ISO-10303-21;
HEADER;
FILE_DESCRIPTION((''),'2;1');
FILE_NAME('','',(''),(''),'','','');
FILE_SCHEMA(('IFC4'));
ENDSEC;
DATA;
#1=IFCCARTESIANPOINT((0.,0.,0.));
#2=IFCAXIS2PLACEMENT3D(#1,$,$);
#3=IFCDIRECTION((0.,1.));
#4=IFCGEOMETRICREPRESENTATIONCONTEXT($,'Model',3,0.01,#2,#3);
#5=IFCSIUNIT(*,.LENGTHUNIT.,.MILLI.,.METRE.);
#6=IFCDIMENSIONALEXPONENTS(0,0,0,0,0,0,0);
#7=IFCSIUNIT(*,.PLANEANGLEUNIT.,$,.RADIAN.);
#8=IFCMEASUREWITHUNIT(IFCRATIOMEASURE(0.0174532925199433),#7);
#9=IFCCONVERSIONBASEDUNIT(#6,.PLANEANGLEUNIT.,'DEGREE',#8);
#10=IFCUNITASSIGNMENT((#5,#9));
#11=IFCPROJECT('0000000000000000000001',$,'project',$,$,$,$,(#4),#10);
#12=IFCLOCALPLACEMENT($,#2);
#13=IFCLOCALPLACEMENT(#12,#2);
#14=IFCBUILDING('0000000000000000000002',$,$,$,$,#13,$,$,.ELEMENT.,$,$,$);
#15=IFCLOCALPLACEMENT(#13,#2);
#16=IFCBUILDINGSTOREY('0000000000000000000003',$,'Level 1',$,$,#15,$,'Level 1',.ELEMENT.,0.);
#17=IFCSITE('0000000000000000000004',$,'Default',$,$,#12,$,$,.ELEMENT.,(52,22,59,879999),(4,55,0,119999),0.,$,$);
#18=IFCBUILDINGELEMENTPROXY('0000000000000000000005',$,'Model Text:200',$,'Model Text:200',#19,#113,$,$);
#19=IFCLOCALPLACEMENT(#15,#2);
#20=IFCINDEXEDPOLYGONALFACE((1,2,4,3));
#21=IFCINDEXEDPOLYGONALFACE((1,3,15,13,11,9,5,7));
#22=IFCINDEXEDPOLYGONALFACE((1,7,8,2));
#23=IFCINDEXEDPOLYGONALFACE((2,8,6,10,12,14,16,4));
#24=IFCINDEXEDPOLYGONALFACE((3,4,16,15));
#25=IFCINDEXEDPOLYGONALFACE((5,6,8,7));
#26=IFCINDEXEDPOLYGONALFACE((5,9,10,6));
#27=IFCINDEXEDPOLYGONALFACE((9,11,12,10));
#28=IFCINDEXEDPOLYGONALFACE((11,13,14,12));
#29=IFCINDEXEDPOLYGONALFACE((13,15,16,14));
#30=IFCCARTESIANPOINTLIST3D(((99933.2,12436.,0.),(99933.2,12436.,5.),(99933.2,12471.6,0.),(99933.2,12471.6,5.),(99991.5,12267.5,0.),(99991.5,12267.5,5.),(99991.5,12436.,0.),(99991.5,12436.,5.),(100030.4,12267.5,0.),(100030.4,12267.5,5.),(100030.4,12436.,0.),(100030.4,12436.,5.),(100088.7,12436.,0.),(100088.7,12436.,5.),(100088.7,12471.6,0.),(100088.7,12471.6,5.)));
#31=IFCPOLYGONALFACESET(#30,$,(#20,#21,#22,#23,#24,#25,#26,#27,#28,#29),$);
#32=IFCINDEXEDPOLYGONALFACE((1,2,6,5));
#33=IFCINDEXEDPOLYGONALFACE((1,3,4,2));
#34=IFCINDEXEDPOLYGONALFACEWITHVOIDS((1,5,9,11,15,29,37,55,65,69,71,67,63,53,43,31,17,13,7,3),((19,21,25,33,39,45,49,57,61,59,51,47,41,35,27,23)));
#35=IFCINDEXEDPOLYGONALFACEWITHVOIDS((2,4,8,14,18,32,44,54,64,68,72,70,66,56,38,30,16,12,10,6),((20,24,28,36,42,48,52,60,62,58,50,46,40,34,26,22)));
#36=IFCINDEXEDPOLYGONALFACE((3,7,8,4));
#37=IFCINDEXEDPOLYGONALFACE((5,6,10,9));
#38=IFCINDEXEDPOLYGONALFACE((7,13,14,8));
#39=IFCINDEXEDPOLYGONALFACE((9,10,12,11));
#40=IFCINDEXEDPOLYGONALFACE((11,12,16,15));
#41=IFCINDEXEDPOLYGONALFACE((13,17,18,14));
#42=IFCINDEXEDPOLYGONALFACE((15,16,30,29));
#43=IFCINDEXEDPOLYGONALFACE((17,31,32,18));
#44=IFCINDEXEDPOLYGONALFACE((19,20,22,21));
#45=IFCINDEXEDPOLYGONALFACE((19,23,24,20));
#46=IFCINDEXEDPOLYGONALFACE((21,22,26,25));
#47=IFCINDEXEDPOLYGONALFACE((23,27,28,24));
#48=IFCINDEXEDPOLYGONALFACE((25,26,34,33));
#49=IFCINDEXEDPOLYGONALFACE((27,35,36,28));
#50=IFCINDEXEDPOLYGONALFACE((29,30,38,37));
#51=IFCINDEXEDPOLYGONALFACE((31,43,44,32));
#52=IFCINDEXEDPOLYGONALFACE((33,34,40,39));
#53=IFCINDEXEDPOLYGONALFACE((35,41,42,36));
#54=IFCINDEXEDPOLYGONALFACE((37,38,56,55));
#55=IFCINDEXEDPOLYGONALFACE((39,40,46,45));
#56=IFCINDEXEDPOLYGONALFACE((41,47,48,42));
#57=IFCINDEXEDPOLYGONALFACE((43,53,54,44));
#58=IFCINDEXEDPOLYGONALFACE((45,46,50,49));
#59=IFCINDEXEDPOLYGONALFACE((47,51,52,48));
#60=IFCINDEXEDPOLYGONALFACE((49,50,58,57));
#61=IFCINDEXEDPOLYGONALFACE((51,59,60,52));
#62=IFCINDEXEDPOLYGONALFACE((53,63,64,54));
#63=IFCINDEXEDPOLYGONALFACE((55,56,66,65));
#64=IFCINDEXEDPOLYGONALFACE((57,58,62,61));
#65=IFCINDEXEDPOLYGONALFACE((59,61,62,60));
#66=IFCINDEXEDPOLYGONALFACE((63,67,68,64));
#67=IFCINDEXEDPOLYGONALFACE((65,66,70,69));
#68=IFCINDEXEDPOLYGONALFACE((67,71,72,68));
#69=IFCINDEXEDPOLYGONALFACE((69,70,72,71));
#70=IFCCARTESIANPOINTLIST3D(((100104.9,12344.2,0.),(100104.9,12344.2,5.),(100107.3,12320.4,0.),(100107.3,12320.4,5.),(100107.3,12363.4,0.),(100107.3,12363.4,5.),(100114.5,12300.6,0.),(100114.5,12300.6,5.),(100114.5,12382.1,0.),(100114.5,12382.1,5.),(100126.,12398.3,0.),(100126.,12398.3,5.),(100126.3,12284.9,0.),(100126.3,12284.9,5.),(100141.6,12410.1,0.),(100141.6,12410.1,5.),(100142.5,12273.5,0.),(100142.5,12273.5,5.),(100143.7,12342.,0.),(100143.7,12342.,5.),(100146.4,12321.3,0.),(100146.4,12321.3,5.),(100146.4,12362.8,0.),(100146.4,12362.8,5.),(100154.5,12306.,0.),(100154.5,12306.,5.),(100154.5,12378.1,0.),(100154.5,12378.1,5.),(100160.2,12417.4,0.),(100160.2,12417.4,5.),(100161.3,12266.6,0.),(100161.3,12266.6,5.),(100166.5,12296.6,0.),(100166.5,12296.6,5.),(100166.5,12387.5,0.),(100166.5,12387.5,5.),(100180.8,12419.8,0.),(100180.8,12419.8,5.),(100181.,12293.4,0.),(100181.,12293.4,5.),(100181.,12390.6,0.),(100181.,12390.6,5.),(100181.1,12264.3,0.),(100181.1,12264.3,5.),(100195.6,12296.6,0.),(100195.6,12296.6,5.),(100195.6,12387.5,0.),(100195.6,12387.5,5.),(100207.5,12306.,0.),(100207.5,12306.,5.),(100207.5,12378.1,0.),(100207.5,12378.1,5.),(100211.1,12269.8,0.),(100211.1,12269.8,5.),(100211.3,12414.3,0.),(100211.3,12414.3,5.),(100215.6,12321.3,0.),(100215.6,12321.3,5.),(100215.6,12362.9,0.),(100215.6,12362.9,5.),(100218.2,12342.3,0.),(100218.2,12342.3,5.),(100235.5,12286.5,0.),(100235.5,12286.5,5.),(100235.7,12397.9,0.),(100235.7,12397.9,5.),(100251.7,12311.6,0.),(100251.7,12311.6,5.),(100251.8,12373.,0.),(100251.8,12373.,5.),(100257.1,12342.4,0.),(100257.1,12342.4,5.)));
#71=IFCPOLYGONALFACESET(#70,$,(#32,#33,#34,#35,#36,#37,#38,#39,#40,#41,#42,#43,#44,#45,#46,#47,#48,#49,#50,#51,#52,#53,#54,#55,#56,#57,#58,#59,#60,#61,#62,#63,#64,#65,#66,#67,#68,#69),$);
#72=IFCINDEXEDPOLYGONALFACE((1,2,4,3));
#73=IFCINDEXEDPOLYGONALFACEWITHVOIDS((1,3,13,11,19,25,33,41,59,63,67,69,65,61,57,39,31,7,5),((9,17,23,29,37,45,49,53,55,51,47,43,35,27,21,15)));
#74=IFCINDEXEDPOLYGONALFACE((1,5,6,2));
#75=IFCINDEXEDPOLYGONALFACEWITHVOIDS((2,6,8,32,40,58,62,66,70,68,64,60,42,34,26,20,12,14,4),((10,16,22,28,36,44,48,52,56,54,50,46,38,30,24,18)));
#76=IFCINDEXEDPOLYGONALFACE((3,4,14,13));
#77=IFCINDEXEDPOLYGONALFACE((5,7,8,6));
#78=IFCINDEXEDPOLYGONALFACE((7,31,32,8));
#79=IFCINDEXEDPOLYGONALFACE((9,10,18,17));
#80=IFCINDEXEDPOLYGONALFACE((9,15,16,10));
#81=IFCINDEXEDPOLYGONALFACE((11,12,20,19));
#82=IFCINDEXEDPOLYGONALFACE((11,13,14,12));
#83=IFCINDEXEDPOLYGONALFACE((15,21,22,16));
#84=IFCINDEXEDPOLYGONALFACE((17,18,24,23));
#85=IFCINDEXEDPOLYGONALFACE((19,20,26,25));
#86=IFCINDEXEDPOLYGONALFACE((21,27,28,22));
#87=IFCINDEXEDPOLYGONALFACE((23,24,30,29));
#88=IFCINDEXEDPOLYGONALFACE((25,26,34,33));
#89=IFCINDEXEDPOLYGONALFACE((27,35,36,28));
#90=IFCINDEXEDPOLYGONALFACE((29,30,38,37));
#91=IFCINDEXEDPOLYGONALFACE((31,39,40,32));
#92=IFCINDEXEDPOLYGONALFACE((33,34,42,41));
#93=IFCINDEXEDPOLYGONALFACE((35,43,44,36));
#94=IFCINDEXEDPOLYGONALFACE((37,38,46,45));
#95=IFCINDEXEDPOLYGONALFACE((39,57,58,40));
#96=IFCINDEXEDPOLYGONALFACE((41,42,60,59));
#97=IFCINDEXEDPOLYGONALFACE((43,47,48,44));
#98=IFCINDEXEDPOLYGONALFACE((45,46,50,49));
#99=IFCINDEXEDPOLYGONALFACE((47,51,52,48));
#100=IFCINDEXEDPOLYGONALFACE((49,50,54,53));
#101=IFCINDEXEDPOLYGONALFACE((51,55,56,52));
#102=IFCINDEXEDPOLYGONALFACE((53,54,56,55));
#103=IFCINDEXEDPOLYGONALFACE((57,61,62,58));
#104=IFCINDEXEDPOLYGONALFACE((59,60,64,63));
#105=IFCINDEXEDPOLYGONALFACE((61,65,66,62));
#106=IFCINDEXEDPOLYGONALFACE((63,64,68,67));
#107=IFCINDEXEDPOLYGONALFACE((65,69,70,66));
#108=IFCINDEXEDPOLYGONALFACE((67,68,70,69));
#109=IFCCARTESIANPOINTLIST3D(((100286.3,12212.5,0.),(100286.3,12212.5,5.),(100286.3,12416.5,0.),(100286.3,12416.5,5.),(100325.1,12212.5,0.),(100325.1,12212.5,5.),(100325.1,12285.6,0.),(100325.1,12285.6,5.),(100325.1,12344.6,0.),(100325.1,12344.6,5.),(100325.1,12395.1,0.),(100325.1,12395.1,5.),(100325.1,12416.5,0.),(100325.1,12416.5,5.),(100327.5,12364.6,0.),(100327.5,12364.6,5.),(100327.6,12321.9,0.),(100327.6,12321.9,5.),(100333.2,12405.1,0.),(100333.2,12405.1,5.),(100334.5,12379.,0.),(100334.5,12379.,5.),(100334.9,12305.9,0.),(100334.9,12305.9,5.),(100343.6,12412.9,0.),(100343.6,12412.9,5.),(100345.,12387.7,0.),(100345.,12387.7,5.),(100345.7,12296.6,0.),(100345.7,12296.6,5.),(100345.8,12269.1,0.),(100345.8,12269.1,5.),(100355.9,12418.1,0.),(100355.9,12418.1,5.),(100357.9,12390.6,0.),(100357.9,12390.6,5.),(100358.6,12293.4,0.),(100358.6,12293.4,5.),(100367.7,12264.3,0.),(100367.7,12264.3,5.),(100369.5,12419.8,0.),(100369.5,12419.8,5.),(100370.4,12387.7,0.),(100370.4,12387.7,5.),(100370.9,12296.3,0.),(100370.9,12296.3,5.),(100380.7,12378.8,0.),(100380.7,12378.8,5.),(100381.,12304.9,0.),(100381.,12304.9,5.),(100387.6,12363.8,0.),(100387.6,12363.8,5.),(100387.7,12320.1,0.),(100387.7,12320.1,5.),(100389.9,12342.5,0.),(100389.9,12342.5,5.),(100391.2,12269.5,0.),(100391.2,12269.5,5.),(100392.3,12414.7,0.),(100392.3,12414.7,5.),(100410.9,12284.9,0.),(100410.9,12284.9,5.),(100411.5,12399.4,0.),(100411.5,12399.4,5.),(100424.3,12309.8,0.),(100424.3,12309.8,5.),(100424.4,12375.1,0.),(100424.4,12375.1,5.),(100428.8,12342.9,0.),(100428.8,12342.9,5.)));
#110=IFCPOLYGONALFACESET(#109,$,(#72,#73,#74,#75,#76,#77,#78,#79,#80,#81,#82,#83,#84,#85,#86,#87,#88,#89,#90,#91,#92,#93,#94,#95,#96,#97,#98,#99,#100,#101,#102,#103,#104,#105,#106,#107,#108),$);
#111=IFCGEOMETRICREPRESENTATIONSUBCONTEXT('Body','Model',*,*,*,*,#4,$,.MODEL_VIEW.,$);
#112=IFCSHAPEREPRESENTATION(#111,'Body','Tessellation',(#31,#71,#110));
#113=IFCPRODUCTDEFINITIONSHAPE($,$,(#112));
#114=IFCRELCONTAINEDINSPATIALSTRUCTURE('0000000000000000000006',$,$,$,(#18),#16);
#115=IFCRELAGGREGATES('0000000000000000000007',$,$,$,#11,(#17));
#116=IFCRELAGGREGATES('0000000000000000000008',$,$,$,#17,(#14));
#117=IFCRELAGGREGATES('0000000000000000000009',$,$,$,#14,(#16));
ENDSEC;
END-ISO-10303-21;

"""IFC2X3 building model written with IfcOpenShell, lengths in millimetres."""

from ifc_helpers import new_model, entity, si_unit, converted_unit, direction, frame, origin, place, context, subcontext, project, spatial, polyline, outline, extrude, element, save


model = new_model("IFC2X3")

# Units and contexts
model_context = context("Model", 3, precision=0.01, world=origin(), true_north=direction((0.0, 1.0)))
body_context = subcontext(model_context, "Body", "Model", "MODEL_VIEW")
ifc_project = project(units=[si_unit("LENGTHUNIT", "METRE", prefix="MILLI"), converted_unit("PLANEANGLEUNIT", "DEGREE", entity("IfcRatioMeasure", 0.0174532925199433), si_unit("PLANEANGLEUNIT", "RADIAN"), dimensions=[0, 0, 0, 0, 0, 0, 0])], contexts=[model_context])

# Site, building, storey
site_placement = place(None, origin())
site = spatial("IfcSite", under=ifc_project, at=site_placement, Name="Default", CompositionType="ELEMENT", RefLatitude=(52, 22, 59, 879999), RefLongitude=(4, 55, 0, 119999), RefElevation=0.0)
building_placement = place(site_placement, origin())
building = spatial("IfcBuilding", under=site, at=building_placement, CompositionType="ELEMENT")
storey_placement = place(building_placement, origin())
storey = spatial("IfcBuildingStorey", under=building, at=storey_placement, Name="Level 1", LongName="Level 1", CompositionType="ELEMENT", Elevation=0.0)

# Building element proxy
proxy_1_placement = place(building_placement, origin())
element("IfcBuildingElementProxy", 1, at=proxy_1_placement, inside=storey, Name="Model Text:200", ObjectType="Model Text:200", context=body_context, shape_type="SweptSolid", body=[
    extrude(outline(polyline([(-19.4, -135.2), (19.4, -135.2), (19.4, 33.2), (77.7, 33.2), (77.7, 68.8), (-77.7, 68.8), (-77.7, 33.2), (-19.4, 33.2), (-19.4, -135.2)])), frame((100010.9, 12402.8, 0.0)), (0.0, 0.0, 1.0), 5.0),
    extrude(outline(polyline([(-8.8, -65.7), (15.1, -65.7), (35.5, -60.5), (52.3, -50.4), (65.3, -35.4), (74.1, -17.3), (78.4, 2.1), (75.9, 32.5), (61.8, 58.5), (38.4, 77.1), (8.3, 85.6), (-22.7, 83.3), (-49.0, 69.9), (-67.8, 47.3), (-76.3, 17.5), (-76.0, -3.3), (-70.7, -22.5), (-60.5, -39.2), (-45.5, -52.3), (-27.7, -61.4), (-8.8, -65.7)]), holes=[polyline([(-2.7, -27.2), (-23.1, -22.5), (-37.5, -12.9), (-45.7, 0.0), (-47.3, 14.8), (-42.7, 28.9), (-32.2, 39.9), (-16.3, 46.3), (4.5, 46.9), (25.1, 42.1), (39.6, 32.6), (47.7, 19.7), (49.4, 5.0), (44.8, -9.2), (34.2, -20.2), (18.2, -26.7), (-2.7, -27.2)])]), frame((100171.1, 12342.1, 0.0), z_axis=(0.0, 0.0, 1.0), x_axis=(0.100608, -0.994926, 0.0)), (0.0, 0.0, 1.0), 5.0),
    extrude(outline(polyline([(-73.1, -75.4), (130.9, -75.4), (130.9, -36.6), (57.8, -36.6), (74.3, -15.9), (79.1, 6.0), (73.9, 29.5), (58.4, 49.2), (33.6, 62.6), (0.5, 67.1), (-31.8, 62.8), (-56.1, 49.8), (-71.3, 30.7), (-76.4, 7.8), (-74.7, -5.8), (-69.6, -18.1), (-61.7, -28.5), (-51.7, -36.6), (-73.1, -36.6), (-73.1, -75.4)]), holes=[polyline([(-1.2, -36.6), (-21.2, -34.2), (-35.6, -27.2), (-44.3, -16.7), (-47.2, -3.8), (-44.3, 8.7), (-35.4, 19.0), (-20.4, 25.9), (0.8, 28.2), (23.3, 26.0), (38.5, 19.3), (47.1, 9.2), (49.9, -3.1), (46.8, -16.0), (37.4, -26.8), (21.5, -34.1), (-1.2, -36.6)])]), frame((100361.7, 12343.4, 0.0), z_axis=(0.0, 0.0, 1.0), x_axis=(0.0, -1.0, 0.0)), (0.0, 0.0, 1.0), 5.0),
])

save(model, "model.ifc")
